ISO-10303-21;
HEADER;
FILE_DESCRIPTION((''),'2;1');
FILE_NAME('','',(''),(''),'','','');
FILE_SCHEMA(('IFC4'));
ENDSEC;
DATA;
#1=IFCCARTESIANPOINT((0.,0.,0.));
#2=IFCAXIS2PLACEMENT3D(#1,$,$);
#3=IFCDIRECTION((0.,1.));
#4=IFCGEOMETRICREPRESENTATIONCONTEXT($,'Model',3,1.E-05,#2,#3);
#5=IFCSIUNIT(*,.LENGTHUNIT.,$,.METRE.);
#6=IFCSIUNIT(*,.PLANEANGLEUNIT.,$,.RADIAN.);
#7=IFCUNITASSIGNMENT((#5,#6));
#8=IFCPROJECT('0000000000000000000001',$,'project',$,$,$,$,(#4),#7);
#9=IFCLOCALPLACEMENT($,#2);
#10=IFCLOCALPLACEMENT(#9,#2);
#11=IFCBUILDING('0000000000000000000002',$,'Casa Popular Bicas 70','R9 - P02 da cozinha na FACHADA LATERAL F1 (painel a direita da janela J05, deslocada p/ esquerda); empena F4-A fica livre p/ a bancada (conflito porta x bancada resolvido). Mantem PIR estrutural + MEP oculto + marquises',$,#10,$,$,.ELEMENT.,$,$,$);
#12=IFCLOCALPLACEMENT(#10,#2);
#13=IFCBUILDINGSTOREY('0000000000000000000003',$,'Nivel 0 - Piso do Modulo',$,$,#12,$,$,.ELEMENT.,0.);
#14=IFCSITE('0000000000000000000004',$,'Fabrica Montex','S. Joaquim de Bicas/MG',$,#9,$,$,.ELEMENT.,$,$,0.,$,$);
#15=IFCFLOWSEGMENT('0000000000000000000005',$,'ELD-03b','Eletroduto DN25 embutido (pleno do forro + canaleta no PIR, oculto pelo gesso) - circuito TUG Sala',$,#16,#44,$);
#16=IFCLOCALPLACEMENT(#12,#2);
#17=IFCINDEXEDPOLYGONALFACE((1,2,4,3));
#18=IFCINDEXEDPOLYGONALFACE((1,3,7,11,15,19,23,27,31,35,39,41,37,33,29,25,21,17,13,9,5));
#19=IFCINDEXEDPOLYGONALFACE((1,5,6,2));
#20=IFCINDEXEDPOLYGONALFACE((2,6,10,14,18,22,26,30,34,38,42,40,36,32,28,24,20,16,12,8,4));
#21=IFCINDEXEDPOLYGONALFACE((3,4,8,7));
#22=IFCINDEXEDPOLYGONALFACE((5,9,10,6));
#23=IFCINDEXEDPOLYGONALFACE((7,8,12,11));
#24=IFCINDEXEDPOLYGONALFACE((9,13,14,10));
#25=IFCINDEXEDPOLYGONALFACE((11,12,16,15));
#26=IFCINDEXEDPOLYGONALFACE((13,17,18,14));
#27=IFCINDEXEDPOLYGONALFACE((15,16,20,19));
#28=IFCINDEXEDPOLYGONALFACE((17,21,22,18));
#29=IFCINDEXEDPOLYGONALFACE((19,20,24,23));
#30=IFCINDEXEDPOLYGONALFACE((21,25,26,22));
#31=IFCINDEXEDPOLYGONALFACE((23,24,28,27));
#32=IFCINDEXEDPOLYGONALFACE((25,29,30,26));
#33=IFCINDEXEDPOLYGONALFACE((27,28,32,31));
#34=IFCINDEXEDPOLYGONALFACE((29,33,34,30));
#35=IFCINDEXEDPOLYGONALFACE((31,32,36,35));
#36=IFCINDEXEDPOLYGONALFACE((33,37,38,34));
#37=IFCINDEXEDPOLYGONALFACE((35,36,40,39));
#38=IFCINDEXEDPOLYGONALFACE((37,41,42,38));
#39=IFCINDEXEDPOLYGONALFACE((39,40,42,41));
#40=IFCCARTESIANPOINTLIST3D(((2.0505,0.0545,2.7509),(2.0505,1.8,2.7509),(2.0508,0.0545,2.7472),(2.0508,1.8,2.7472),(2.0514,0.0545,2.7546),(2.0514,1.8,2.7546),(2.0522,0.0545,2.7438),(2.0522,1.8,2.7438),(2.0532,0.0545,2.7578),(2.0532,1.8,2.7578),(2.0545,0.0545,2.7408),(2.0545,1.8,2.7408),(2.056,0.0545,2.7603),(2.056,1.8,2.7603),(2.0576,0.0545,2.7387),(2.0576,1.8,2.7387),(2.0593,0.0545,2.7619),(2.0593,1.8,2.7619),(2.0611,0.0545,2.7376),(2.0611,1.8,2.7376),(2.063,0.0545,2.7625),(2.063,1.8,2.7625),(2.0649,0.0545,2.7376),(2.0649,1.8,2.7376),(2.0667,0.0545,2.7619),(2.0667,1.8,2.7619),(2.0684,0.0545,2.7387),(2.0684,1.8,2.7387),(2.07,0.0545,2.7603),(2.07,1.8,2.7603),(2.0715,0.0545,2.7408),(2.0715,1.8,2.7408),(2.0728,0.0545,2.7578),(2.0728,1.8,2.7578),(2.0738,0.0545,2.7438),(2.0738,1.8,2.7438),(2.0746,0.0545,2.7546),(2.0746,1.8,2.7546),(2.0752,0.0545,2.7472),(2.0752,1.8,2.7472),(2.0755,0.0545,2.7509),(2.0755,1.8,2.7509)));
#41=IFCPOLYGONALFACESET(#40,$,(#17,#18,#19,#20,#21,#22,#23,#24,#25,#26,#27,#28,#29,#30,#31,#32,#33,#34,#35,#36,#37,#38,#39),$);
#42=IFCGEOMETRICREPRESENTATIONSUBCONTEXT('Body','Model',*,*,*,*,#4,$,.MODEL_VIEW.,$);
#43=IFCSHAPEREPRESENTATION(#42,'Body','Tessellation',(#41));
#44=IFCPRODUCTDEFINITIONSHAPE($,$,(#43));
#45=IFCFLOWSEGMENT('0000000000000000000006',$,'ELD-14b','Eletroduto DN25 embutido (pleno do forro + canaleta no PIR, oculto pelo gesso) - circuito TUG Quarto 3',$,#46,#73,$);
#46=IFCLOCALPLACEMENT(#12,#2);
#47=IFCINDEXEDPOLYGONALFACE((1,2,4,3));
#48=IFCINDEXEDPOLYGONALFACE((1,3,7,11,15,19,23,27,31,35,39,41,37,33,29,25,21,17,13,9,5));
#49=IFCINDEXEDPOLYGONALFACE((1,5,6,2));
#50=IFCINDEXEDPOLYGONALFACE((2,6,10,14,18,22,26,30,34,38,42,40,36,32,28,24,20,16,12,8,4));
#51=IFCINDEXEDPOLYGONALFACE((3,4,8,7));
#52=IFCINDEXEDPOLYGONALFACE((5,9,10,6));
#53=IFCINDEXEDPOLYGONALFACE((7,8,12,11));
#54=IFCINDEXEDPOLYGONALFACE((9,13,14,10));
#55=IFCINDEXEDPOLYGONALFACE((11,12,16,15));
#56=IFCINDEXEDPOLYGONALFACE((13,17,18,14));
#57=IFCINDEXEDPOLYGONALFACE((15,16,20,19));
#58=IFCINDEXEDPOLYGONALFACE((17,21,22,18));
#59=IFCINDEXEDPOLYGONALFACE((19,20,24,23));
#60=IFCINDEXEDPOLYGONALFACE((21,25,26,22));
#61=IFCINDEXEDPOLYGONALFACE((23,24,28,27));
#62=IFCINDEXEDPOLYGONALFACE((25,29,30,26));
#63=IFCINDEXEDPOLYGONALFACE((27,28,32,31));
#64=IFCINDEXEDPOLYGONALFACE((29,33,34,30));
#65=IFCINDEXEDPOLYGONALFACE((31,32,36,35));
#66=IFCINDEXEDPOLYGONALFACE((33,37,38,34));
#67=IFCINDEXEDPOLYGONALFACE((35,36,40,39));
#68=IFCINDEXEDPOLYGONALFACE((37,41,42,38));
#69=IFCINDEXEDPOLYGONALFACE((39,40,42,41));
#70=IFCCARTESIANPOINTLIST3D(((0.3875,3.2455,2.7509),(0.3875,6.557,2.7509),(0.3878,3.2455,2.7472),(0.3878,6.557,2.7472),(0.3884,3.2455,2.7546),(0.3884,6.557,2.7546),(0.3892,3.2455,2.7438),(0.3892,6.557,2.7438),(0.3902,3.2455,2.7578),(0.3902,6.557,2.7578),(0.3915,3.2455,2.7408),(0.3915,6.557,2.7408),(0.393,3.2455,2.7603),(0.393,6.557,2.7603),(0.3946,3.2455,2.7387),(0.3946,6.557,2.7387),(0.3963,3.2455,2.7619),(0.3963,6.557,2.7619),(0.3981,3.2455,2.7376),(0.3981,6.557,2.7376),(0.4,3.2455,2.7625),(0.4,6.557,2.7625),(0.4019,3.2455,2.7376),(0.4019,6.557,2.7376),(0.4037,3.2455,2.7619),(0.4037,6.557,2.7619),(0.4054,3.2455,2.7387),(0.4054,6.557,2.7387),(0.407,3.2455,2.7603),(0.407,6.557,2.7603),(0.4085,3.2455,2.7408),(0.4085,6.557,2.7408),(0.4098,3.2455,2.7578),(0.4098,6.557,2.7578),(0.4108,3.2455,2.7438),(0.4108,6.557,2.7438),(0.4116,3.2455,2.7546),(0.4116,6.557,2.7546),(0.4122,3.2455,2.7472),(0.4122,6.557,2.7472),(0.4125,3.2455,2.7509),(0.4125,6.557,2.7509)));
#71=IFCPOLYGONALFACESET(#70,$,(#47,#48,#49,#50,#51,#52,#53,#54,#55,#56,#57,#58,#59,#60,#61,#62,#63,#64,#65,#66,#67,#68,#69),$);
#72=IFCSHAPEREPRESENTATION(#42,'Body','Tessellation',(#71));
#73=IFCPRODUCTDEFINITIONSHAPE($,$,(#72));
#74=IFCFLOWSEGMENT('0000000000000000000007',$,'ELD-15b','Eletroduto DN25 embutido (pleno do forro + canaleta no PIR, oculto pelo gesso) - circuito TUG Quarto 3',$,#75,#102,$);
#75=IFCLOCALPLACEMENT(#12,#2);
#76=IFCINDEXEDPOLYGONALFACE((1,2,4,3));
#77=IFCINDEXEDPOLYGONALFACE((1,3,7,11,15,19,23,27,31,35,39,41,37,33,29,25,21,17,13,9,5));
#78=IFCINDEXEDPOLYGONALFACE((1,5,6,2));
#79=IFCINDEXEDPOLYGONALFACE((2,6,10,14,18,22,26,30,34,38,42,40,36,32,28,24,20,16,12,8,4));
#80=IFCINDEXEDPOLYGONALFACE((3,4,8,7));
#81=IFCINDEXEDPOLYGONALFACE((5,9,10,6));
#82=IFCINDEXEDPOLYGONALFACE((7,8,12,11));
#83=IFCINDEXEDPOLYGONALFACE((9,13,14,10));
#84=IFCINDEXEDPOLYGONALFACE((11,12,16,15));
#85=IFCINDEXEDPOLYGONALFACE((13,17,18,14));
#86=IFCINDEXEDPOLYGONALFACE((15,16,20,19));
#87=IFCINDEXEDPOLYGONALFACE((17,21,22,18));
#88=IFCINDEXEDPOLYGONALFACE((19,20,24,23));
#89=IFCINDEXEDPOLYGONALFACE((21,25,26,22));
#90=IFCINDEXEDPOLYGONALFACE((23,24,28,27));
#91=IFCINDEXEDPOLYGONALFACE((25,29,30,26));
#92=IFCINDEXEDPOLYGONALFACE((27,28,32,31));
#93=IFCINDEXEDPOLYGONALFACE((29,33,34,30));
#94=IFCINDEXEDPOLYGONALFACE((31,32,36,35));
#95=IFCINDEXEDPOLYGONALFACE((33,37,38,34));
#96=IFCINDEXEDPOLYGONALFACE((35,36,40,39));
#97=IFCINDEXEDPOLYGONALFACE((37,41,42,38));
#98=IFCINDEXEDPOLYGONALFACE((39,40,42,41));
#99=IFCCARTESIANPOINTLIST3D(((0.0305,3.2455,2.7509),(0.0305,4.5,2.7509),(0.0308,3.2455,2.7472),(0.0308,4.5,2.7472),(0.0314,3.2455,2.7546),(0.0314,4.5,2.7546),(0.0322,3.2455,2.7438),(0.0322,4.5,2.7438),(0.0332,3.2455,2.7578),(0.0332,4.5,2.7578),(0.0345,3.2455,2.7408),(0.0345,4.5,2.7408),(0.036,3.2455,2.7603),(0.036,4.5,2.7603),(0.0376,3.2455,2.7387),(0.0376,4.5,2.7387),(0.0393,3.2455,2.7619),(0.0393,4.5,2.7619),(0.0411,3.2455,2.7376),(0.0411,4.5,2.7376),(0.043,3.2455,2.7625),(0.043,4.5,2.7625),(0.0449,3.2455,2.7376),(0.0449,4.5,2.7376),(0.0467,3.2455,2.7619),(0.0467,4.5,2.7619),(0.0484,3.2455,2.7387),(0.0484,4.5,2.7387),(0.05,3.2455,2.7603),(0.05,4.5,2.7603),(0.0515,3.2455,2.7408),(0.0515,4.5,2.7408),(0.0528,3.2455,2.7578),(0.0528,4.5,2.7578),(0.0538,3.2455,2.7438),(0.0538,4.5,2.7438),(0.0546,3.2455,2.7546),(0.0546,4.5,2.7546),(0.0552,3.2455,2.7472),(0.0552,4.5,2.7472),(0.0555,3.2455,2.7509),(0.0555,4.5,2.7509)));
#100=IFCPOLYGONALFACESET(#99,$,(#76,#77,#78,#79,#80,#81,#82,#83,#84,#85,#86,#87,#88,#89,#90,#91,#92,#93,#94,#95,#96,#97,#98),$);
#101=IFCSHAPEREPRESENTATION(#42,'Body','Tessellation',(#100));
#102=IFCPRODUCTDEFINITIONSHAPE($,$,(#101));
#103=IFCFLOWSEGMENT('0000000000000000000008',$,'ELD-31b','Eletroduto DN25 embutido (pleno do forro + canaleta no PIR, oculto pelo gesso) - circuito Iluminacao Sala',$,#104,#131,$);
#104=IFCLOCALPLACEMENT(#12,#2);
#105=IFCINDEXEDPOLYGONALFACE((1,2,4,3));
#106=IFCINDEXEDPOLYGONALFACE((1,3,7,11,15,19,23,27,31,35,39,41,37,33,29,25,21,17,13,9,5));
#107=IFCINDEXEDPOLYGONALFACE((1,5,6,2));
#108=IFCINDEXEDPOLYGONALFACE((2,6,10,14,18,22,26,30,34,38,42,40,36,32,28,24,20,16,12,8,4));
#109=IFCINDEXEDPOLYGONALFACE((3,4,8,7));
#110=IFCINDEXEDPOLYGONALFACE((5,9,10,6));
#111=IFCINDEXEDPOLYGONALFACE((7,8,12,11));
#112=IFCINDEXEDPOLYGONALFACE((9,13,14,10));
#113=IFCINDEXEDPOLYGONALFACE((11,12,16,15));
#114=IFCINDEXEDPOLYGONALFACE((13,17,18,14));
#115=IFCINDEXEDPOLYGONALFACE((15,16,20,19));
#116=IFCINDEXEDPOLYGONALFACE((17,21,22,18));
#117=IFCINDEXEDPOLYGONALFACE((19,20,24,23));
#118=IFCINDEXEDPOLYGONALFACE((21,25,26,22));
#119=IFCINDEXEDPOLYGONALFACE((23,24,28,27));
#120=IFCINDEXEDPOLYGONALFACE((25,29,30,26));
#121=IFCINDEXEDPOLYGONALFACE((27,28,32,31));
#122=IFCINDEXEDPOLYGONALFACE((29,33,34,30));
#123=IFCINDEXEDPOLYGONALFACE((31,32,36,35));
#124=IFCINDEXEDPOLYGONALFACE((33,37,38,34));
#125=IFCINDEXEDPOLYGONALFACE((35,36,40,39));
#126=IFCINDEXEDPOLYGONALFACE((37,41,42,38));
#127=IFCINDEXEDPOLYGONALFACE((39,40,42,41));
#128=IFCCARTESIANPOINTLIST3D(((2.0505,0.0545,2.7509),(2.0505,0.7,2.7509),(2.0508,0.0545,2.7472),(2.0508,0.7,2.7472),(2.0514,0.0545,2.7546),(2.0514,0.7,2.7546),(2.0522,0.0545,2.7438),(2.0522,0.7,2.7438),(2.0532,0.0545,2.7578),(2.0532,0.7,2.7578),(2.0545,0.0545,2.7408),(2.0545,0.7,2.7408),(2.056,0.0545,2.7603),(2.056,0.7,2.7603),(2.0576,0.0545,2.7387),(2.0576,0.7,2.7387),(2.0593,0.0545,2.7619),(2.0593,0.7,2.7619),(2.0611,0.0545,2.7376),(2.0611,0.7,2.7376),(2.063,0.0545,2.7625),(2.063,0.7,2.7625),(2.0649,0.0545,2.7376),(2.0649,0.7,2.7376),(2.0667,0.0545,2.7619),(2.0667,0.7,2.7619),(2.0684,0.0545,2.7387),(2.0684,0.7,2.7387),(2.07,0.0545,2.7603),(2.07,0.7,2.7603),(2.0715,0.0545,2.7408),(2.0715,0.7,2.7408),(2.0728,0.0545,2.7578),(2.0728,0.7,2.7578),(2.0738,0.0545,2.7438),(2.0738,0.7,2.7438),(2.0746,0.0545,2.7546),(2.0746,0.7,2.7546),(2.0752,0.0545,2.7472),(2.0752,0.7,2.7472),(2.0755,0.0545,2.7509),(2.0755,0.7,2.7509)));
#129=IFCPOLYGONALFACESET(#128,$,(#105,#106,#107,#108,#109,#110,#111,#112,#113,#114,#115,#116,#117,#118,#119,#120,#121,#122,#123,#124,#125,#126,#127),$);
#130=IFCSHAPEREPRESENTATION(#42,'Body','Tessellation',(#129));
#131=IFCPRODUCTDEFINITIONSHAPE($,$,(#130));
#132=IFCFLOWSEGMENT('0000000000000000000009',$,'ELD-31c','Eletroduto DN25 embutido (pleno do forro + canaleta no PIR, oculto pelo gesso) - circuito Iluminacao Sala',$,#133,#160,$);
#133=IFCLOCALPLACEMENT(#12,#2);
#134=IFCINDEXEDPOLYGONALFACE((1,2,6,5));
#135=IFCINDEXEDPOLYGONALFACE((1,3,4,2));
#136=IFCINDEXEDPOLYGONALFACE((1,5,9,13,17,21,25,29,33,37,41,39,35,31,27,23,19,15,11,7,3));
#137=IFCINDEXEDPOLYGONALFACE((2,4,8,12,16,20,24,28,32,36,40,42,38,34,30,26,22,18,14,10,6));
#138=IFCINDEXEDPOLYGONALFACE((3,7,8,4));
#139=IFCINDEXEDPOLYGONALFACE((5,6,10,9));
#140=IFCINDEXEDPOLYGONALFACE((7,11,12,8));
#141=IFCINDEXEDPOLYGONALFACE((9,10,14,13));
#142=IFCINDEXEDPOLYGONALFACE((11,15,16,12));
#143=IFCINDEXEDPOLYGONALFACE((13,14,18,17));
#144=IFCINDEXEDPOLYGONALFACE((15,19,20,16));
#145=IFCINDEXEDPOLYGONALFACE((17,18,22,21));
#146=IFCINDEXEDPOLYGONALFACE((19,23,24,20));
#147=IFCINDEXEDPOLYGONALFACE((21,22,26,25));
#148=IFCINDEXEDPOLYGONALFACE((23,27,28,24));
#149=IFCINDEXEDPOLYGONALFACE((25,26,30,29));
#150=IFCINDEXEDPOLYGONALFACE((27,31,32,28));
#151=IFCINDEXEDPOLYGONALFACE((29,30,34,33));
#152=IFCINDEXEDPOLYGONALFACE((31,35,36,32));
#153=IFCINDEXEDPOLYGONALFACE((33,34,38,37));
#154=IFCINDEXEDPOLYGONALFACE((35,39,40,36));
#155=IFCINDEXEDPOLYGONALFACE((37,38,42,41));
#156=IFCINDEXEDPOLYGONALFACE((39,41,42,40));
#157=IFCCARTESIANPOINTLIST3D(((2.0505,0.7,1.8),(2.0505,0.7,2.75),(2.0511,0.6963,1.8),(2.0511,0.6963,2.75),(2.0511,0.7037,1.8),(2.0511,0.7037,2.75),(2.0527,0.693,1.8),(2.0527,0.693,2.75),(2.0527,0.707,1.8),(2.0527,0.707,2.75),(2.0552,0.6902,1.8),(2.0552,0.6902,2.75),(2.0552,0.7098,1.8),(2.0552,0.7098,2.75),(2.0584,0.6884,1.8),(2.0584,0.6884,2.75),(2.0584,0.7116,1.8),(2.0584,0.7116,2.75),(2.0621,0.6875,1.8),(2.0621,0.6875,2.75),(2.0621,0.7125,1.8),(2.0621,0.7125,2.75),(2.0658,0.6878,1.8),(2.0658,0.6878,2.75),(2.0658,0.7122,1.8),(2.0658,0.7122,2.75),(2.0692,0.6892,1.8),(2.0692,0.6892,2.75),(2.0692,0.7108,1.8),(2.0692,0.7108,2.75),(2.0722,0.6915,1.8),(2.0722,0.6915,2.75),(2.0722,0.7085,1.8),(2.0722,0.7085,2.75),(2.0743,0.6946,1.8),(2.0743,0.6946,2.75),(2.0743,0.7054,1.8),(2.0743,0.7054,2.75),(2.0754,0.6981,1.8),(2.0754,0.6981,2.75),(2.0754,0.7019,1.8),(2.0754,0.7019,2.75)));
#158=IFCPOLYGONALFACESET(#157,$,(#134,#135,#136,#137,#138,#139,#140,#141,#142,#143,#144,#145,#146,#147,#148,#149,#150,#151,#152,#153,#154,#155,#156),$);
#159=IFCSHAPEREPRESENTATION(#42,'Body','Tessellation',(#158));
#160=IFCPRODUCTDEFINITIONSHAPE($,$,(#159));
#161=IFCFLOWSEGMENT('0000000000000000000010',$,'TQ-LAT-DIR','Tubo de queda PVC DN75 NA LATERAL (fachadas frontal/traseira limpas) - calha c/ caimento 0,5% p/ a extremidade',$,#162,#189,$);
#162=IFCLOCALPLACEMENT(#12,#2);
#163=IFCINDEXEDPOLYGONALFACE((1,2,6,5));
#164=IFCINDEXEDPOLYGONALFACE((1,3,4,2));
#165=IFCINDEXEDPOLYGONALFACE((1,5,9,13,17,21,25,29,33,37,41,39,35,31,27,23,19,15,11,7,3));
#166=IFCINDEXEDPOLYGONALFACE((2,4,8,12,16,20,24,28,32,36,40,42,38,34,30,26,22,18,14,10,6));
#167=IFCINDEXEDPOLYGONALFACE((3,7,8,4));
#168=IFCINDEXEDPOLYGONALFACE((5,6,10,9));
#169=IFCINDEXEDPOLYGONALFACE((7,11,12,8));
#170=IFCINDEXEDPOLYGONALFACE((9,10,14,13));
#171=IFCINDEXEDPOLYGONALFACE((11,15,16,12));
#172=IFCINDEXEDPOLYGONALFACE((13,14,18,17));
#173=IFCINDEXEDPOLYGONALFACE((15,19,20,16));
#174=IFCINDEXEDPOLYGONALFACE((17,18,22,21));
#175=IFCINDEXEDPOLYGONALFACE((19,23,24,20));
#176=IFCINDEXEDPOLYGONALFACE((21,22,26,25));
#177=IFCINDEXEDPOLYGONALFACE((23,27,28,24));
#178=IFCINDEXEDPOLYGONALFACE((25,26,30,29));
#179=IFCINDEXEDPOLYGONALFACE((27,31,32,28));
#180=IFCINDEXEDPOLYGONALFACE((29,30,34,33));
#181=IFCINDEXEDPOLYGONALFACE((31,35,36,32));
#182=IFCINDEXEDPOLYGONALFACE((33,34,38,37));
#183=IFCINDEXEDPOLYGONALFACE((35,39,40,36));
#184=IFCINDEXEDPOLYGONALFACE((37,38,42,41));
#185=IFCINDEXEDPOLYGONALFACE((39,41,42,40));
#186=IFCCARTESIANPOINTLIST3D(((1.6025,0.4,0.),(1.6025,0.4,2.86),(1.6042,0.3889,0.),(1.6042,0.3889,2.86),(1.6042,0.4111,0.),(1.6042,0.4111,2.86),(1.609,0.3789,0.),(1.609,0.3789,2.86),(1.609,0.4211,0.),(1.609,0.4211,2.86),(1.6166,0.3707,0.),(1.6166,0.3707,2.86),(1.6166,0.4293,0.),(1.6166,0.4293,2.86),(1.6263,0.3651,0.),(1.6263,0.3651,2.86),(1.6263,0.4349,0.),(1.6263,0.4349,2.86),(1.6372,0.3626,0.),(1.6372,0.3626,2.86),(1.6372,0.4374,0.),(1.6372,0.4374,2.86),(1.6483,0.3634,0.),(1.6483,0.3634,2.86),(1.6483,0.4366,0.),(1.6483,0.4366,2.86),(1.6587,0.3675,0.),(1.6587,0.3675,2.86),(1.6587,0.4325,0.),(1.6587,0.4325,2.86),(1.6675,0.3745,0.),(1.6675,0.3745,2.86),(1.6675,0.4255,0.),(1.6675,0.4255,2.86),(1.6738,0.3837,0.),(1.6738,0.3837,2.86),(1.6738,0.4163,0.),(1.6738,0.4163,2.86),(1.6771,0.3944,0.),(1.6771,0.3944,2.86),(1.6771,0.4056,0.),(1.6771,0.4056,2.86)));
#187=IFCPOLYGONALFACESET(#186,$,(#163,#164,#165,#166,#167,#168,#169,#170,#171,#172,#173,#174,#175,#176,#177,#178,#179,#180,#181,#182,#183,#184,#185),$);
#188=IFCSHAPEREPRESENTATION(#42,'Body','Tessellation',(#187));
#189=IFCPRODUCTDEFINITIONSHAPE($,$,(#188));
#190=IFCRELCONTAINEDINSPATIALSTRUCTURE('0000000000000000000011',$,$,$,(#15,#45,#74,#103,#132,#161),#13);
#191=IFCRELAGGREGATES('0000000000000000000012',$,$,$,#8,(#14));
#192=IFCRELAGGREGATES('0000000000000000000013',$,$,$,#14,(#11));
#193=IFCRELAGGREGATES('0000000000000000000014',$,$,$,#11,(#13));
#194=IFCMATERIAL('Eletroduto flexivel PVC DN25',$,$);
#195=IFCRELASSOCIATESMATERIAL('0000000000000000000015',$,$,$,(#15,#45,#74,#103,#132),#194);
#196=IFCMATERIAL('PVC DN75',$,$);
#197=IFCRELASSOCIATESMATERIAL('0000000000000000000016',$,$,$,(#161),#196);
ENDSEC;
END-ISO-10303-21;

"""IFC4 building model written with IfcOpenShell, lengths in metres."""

from ifc_helpers import new_model, si_unit, direction, frame, origin, origin_2d, place, context, subcontext, project, spatial, circle, extrude, material, element, save


model = new_model("IFC4")

# Units and contexts
model_context = context("Model", 3, precision=1e-05, world=origin(), true_north=direction((0.0, 1.0)))
body_context = subcontext(model_context, "Body", "Model", "MODEL_VIEW")
ifc_project = project(units=[si_unit("LENGTHUNIT", "METRE"), si_unit("PLANEANGLEUNIT", "RADIAN")], contexts=[model_context])

# Site, building, storey
site_placement = place(None, origin())
site = spatial("IfcSite", under=ifc_project, at=site_placement, Name="Fabrica Montex", Description="S. Joaquim de Bicas/MG", CompositionType="ELEMENT", RefElevation=0.0)
building_placement = place(site_placement, origin())
building = spatial("IfcBuilding", under=site, at=building_placement, Name="Casa Popular Bicas 70", Description="R9 - P02 da cozinha na FACHADA LATERAL F1 (painel a direita da janela J05, deslocada p/ esquerda); empena F4-A fica livre p/ a bancada (conflito porta x bancada resolvido). Mantem PIR estrutural + MEP oculto + marquises", CompositionType="ELEMENT")
storey_placement = place(building_placement, origin())
storey = spatial("IfcBuildingStorey", under=building, at=storey_placement, Name="Nivel 0 - Piso do Modulo", CompositionType="ELEMENT", Elevation=0.0)

# Flow segments
ifc_material_1 = material(Name="Eletroduto flexivel PVC DN25")
flow_segment_1_placement = place(None, frame((2.063, 0.0545, 2.75), z_axis=(0.0, 1.0, 0.0), x_axis=(0.0, 0.0, 1.0)))
element("IfcFlowSegment", 1, at=flow_segment_1_placement, inside=storey, material=ifc_material_1, Name="ELD-03b", Description="Eletroduto DN25 embutido (pleno do forro + canaleta no PIR, oculto pelo gesso) - circuito TUG Sala", context=body_context, shape_type="SweptSolid", body=[
    extrude(circle(Radius=0.0125, at=origin_2d()), origin(), (0.0, 0.0, 1.0), 1.7455),
])
flow_segment_2_placement = place(storey_placement, frame((0.4, 3.2455, 2.75), z_axis=(0.0, 1.0, 0.0), x_axis=(0.0, 0.0, 1.0)))
element("IfcFlowSegment", 2, at=flow_segment_2_placement, inside=storey, material=ifc_material_1, Name="ELD-14b", Description="Eletroduto DN25 embutido (pleno do forro + canaleta no PIR, oculto pelo gesso) - circuito TUG Quarto 3", context=body_context, shape_type="SweptSolid", body=[
    extrude(circle(Radius=0.0125, at=origin_2d()), origin(), (0.0, 0.0, 1.0), 3.3115),
])
flow_segment_3_placement = place(storey_placement, frame((0.043, 3.2455, 2.75), z_axis=(0.0, 1.0, 0.0), x_axis=(0.0, 0.0, 1.0)))
element("IfcFlowSegment", 3, at=flow_segment_3_placement, inside=storey, material=ifc_material_1, Name="ELD-15b", Description="Eletroduto DN25 embutido (pleno do forro + canaleta no PIR, oculto pelo gesso) - circuito TUG Quarto 3", context=body_context, shape_type="SweptSolid", body=[
    extrude(circle(Radius=0.0125, at=origin_2d()), origin(), (0.0, 0.0, 1.0), 1.2545),
])
flow_segment_4_placement = place(None, frame((2.063, 0.0545, 2.75), z_axis=(0.0, 1.0, 0.0), x_axis=(0.0, 0.0, 1.0)))
element("IfcFlowSegment", 4, at=flow_segment_4_placement, inside=storey, material=ifc_material_1, Name="ELD-31b", Description="Eletroduto DN25 embutido (pleno do forro + canaleta no PIR, oculto pelo gesso) - circuito Iluminacao Sala", context=body_context, shape_type="SweptSolid", body=[
    extrude(circle(Radius=0.0125, at=origin_2d()), origin(), (0.0, 0.0, 1.0), 0.6455),
])
flow_segment_5_placement = place(None, frame((2.063, 0.7, 2.75), z_axis=(0.0, 0.0, -1.0), x_axis=(-1.0, 0.0, 0.0)))
element("IfcFlowSegment", 5, at=flow_segment_5_placement, inside=storey, material=ifc_material_1, Name="ELD-31c", Description="Eletroduto DN25 embutido (pleno do forro + canaleta no PIR, oculto pelo gesso) - circuito Iluminacao Sala", context=body_context, shape_type="SweptSolid", body=[
    extrude(circle(Radius=0.0125, at=origin_2d()), origin(), (0.0, 0.0, 1.0), 0.95),
])
ifc_material_2 = material(Name="PVC DN75")
flow_segment_6_placement = place(None, frame((1.64, 0.4, 0.0), z_axis=(0.0, 0.0, 1.0), x_axis=(-1.0, 0.0, 0.0)))
element("IfcFlowSegment", 6, at=flow_segment_6_placement, inside=storey, material=ifc_material_2, Name="TQ-LAT-DIR", Description="Tubo de queda PVC DN75 NA LATERAL (fachadas frontal/traseira limpas) - calha c/ caimento 0,5% p/ a extremidade", context=body_context, shape_type="SweptSolid", body=[
    extrude(circle(Radius=0.0375, at=origin_2d()), origin(), (0.0, 0.0, 1.0), 2.86),
])

save(model, "model.ifc")
